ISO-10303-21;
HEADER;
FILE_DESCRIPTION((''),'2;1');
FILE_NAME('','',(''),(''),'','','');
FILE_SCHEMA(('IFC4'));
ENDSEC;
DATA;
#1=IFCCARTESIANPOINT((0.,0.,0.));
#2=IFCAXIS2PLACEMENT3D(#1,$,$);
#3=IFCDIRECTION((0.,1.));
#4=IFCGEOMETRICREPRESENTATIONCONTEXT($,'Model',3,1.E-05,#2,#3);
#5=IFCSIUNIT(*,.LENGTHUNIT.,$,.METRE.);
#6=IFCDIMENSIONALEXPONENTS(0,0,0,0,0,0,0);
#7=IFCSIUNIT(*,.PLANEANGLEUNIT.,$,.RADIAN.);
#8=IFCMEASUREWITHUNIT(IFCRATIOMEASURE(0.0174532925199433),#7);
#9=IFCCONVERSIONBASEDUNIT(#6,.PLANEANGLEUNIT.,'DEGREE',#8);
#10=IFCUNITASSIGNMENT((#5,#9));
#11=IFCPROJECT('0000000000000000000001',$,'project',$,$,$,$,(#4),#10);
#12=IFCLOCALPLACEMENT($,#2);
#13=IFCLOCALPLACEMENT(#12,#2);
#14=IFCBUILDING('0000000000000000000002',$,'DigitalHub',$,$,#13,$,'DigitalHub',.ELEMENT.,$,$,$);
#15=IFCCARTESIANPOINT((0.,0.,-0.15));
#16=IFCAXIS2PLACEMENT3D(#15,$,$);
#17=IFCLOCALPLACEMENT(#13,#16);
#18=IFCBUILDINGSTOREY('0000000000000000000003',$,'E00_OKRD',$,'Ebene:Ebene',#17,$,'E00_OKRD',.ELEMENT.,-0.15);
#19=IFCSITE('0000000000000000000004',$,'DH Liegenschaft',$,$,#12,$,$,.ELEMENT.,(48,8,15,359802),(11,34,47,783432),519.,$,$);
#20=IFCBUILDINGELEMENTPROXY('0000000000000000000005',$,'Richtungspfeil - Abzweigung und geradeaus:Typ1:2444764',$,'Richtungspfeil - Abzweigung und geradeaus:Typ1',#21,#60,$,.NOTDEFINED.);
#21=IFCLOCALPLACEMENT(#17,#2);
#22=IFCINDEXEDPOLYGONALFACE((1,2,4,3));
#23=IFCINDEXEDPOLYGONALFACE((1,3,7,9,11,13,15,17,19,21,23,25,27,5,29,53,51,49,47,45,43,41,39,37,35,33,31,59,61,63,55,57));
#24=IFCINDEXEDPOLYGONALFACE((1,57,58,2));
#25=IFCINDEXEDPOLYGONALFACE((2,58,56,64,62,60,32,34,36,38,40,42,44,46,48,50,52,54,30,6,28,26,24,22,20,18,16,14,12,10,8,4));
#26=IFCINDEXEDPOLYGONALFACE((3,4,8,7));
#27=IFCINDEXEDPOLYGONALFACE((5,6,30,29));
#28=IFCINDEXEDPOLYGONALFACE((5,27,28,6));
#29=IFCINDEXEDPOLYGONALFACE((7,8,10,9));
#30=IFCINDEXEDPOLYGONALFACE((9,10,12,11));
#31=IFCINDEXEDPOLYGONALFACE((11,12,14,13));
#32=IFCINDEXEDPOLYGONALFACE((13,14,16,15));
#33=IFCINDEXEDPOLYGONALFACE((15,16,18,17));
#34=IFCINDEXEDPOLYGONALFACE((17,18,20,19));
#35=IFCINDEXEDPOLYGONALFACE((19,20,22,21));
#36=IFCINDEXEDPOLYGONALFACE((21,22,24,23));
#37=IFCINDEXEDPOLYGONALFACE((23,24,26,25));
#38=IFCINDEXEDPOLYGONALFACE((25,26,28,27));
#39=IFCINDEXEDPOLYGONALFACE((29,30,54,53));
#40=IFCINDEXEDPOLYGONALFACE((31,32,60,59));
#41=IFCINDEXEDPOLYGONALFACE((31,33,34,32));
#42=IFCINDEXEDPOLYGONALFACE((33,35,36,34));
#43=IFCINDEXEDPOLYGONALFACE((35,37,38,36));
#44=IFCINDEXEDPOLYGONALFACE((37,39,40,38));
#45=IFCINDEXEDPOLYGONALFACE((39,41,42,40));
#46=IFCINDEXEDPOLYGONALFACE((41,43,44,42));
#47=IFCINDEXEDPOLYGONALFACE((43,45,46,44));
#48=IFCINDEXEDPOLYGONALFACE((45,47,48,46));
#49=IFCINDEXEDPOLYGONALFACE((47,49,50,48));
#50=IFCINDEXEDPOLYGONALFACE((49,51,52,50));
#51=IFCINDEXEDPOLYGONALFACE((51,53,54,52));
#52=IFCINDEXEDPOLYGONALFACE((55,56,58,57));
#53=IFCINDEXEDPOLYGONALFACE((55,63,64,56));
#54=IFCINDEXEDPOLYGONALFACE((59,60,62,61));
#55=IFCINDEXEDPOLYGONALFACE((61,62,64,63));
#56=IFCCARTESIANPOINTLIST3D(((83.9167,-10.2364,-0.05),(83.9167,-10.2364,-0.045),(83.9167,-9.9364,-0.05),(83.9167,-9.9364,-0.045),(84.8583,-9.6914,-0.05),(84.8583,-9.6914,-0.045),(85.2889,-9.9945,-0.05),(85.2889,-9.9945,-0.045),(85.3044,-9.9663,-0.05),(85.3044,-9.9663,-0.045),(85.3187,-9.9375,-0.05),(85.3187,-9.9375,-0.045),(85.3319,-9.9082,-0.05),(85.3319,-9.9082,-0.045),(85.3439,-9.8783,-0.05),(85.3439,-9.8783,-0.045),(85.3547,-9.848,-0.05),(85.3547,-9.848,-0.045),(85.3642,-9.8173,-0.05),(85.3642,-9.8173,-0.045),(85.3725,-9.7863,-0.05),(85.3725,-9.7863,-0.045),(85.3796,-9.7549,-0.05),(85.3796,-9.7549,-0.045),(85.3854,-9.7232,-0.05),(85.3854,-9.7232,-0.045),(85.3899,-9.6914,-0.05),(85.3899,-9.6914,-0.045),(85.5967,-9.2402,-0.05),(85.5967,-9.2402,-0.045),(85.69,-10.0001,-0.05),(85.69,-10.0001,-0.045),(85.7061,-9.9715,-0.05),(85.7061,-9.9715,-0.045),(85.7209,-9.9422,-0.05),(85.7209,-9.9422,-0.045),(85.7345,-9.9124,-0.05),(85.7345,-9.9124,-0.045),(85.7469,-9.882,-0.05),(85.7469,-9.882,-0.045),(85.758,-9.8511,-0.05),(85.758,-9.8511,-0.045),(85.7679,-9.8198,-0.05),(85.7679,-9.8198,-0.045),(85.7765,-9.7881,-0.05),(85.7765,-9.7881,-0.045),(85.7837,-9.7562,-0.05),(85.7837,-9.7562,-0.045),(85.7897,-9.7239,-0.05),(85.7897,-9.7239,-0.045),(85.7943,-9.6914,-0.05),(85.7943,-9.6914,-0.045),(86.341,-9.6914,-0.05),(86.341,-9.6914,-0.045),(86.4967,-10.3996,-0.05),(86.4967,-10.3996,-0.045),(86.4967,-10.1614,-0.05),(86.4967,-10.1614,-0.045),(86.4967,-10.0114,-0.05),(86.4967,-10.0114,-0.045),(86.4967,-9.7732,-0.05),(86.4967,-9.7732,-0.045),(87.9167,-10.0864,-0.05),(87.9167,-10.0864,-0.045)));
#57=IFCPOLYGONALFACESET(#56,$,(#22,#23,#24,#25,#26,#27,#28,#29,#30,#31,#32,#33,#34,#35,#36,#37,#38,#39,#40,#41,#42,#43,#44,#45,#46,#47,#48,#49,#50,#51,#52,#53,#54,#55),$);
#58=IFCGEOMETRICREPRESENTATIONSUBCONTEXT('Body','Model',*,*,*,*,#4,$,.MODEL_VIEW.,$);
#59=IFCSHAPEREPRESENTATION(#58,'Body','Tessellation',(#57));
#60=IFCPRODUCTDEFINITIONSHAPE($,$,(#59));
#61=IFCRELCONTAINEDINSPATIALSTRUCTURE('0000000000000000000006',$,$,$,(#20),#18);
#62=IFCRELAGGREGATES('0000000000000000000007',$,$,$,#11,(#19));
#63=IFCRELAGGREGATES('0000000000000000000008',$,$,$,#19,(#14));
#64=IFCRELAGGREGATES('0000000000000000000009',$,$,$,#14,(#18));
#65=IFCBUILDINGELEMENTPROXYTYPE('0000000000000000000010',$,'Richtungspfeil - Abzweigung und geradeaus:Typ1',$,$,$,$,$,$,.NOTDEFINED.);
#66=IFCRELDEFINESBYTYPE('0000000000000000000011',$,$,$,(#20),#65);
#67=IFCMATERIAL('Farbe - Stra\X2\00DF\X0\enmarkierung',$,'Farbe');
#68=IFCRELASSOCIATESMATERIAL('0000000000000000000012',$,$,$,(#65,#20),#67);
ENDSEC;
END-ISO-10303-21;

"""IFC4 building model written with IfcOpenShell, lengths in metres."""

from ifc_helpers import new_model, entity, si_unit, converted_unit, direction, frame, origin, place, context, subcontext, project, spatial, indexed_curve, outline, extrude, source, transform, mapped, material, type_object, type_shapes, element, save


model = new_model("IFC4")

# Units and contexts
model_context = context("Model", 3, precision=1e-05, world=origin(), true_north=direction((0.0, 1.0)))
body_context = subcontext(model_context, "Body", "Model", "MODEL_VIEW")
ifc_project = project(units=[si_unit("LENGTHUNIT", "METRE"), converted_unit("PLANEANGLEUNIT", "DEGREE", entity("IfcRatioMeasure", 0.0174532925199433), si_unit("PLANEANGLEUNIT", "RADIAN"), dimensions=[0, 0, 0, 0, 0, 0, 0])], contexts=[model_context])

# Site, building, storey
site_placement = place(None, frame((0.0, 0.0, 0.0)))
site = spatial("IfcSite", under=ifc_project, at=site_placement, Name="DH Liegenschaft", CompositionType="ELEMENT", RefLatitude=(48, 8, 15, 359802), RefLongitude=(11, 34, 47, 783432), RefElevation=519.0)
building_placement = place(site_placement, origin())
building = spatial("IfcBuilding", under=site, at=building_placement, Name="DigitalHub", LongName="DigitalHub", CompositionType="ELEMENT")
storey_placement = place(building_placement, frame((0.0, 0.0, -0.15)))
storey = spatial("IfcBuildingStorey", under=building, at=storey_placement, Name="E00_OKRD", ObjectType="Ebene:Ebene", LongName="E00_OKRD", CompositionType="ELEMENT", Elevation=-0.15)

# Building element proxy
ifc_material_1 = material(Name="Farbe - Straßenmarkierung", Category="Farbe")
building_element_proxy_type_1 = type_object("IfcBuildingElementProxyType", Name="Richtungspfeil - Abzweigung und geradeaus:Typ1", PredefinedType="NOTDEFINED", material=ifc_material_1)
shared_shape_1 = source(origin(), body_context, "Body", "SweptSolid", [
    extrude(outline(indexed_curve([(0.261, 0.7327), (0.4993, 0.7327), (0.186, 2.1527), (-0.1272, 0.7327), (0.111, 0.7327), (0.0997, -0.0739), (0.0711, -0.0579), (0.0418, -0.0431), (0.012, -0.0295), (-0.0184, -0.0171), (-0.0493, -0.0059), (-0.0806, 0.0039), (-0.1122, 0.0125), (-0.1442, 0.0198), (-0.1765, 0.0257), (-0.209, 0.0303), (-0.209, 0.577), (-0.6601, -0.1673), (-0.209, -0.9056), (-0.209, -0.3741), (-0.1771, -0.3786), (-0.1455, -0.3844), (-0.1141, -0.3914), (-0.0831, -0.3998), (-0.0524, -0.4093), (-0.0221, -0.4201), (0.0078, -0.4321), (0.0371, -0.4452), (0.0659, -0.4596), (0.0941, -0.4751), (0.036, -1.8473), (0.336, -1.8473), (0.261, 0.7327)], self_intersect=False)), frame((0.261, -1.8473, 0.0), z_axis=(0.0, 0.0, 1.0), x_axis=(-1.0, 0.0, 0.0)), (0.0, 0.0, 1.0), 0.005),
])
type_shapes(building_element_proxy_type_1, [shared_shape_1])
proxy_1_placement = place(storey_placement, frame((83.9167, -10.1614, -0.05), z_axis=(0.0, 0.0, 1.0), x_axis=(0.0, 1.0, 0.0)))
element("IfcBuildingElementProxy", 1, at=proxy_1_placement, inside=storey, type_object=building_element_proxy_type_1, material=ifc_material_1, Name="Richtungspfeil - Abzweigung und geradeaus:Typ1:2444764", ObjectType="Richtungspfeil - Abzweigung und geradeaus:Typ1", PredefinedType="NOTDEFINED", context=body_context, shape_type="MappedRepresentation", body=[
    mapped(shared_shape_1, transform((0.0, 0.0, 0.0), scale=1.0)),
])

save(model, "model.ifc")
